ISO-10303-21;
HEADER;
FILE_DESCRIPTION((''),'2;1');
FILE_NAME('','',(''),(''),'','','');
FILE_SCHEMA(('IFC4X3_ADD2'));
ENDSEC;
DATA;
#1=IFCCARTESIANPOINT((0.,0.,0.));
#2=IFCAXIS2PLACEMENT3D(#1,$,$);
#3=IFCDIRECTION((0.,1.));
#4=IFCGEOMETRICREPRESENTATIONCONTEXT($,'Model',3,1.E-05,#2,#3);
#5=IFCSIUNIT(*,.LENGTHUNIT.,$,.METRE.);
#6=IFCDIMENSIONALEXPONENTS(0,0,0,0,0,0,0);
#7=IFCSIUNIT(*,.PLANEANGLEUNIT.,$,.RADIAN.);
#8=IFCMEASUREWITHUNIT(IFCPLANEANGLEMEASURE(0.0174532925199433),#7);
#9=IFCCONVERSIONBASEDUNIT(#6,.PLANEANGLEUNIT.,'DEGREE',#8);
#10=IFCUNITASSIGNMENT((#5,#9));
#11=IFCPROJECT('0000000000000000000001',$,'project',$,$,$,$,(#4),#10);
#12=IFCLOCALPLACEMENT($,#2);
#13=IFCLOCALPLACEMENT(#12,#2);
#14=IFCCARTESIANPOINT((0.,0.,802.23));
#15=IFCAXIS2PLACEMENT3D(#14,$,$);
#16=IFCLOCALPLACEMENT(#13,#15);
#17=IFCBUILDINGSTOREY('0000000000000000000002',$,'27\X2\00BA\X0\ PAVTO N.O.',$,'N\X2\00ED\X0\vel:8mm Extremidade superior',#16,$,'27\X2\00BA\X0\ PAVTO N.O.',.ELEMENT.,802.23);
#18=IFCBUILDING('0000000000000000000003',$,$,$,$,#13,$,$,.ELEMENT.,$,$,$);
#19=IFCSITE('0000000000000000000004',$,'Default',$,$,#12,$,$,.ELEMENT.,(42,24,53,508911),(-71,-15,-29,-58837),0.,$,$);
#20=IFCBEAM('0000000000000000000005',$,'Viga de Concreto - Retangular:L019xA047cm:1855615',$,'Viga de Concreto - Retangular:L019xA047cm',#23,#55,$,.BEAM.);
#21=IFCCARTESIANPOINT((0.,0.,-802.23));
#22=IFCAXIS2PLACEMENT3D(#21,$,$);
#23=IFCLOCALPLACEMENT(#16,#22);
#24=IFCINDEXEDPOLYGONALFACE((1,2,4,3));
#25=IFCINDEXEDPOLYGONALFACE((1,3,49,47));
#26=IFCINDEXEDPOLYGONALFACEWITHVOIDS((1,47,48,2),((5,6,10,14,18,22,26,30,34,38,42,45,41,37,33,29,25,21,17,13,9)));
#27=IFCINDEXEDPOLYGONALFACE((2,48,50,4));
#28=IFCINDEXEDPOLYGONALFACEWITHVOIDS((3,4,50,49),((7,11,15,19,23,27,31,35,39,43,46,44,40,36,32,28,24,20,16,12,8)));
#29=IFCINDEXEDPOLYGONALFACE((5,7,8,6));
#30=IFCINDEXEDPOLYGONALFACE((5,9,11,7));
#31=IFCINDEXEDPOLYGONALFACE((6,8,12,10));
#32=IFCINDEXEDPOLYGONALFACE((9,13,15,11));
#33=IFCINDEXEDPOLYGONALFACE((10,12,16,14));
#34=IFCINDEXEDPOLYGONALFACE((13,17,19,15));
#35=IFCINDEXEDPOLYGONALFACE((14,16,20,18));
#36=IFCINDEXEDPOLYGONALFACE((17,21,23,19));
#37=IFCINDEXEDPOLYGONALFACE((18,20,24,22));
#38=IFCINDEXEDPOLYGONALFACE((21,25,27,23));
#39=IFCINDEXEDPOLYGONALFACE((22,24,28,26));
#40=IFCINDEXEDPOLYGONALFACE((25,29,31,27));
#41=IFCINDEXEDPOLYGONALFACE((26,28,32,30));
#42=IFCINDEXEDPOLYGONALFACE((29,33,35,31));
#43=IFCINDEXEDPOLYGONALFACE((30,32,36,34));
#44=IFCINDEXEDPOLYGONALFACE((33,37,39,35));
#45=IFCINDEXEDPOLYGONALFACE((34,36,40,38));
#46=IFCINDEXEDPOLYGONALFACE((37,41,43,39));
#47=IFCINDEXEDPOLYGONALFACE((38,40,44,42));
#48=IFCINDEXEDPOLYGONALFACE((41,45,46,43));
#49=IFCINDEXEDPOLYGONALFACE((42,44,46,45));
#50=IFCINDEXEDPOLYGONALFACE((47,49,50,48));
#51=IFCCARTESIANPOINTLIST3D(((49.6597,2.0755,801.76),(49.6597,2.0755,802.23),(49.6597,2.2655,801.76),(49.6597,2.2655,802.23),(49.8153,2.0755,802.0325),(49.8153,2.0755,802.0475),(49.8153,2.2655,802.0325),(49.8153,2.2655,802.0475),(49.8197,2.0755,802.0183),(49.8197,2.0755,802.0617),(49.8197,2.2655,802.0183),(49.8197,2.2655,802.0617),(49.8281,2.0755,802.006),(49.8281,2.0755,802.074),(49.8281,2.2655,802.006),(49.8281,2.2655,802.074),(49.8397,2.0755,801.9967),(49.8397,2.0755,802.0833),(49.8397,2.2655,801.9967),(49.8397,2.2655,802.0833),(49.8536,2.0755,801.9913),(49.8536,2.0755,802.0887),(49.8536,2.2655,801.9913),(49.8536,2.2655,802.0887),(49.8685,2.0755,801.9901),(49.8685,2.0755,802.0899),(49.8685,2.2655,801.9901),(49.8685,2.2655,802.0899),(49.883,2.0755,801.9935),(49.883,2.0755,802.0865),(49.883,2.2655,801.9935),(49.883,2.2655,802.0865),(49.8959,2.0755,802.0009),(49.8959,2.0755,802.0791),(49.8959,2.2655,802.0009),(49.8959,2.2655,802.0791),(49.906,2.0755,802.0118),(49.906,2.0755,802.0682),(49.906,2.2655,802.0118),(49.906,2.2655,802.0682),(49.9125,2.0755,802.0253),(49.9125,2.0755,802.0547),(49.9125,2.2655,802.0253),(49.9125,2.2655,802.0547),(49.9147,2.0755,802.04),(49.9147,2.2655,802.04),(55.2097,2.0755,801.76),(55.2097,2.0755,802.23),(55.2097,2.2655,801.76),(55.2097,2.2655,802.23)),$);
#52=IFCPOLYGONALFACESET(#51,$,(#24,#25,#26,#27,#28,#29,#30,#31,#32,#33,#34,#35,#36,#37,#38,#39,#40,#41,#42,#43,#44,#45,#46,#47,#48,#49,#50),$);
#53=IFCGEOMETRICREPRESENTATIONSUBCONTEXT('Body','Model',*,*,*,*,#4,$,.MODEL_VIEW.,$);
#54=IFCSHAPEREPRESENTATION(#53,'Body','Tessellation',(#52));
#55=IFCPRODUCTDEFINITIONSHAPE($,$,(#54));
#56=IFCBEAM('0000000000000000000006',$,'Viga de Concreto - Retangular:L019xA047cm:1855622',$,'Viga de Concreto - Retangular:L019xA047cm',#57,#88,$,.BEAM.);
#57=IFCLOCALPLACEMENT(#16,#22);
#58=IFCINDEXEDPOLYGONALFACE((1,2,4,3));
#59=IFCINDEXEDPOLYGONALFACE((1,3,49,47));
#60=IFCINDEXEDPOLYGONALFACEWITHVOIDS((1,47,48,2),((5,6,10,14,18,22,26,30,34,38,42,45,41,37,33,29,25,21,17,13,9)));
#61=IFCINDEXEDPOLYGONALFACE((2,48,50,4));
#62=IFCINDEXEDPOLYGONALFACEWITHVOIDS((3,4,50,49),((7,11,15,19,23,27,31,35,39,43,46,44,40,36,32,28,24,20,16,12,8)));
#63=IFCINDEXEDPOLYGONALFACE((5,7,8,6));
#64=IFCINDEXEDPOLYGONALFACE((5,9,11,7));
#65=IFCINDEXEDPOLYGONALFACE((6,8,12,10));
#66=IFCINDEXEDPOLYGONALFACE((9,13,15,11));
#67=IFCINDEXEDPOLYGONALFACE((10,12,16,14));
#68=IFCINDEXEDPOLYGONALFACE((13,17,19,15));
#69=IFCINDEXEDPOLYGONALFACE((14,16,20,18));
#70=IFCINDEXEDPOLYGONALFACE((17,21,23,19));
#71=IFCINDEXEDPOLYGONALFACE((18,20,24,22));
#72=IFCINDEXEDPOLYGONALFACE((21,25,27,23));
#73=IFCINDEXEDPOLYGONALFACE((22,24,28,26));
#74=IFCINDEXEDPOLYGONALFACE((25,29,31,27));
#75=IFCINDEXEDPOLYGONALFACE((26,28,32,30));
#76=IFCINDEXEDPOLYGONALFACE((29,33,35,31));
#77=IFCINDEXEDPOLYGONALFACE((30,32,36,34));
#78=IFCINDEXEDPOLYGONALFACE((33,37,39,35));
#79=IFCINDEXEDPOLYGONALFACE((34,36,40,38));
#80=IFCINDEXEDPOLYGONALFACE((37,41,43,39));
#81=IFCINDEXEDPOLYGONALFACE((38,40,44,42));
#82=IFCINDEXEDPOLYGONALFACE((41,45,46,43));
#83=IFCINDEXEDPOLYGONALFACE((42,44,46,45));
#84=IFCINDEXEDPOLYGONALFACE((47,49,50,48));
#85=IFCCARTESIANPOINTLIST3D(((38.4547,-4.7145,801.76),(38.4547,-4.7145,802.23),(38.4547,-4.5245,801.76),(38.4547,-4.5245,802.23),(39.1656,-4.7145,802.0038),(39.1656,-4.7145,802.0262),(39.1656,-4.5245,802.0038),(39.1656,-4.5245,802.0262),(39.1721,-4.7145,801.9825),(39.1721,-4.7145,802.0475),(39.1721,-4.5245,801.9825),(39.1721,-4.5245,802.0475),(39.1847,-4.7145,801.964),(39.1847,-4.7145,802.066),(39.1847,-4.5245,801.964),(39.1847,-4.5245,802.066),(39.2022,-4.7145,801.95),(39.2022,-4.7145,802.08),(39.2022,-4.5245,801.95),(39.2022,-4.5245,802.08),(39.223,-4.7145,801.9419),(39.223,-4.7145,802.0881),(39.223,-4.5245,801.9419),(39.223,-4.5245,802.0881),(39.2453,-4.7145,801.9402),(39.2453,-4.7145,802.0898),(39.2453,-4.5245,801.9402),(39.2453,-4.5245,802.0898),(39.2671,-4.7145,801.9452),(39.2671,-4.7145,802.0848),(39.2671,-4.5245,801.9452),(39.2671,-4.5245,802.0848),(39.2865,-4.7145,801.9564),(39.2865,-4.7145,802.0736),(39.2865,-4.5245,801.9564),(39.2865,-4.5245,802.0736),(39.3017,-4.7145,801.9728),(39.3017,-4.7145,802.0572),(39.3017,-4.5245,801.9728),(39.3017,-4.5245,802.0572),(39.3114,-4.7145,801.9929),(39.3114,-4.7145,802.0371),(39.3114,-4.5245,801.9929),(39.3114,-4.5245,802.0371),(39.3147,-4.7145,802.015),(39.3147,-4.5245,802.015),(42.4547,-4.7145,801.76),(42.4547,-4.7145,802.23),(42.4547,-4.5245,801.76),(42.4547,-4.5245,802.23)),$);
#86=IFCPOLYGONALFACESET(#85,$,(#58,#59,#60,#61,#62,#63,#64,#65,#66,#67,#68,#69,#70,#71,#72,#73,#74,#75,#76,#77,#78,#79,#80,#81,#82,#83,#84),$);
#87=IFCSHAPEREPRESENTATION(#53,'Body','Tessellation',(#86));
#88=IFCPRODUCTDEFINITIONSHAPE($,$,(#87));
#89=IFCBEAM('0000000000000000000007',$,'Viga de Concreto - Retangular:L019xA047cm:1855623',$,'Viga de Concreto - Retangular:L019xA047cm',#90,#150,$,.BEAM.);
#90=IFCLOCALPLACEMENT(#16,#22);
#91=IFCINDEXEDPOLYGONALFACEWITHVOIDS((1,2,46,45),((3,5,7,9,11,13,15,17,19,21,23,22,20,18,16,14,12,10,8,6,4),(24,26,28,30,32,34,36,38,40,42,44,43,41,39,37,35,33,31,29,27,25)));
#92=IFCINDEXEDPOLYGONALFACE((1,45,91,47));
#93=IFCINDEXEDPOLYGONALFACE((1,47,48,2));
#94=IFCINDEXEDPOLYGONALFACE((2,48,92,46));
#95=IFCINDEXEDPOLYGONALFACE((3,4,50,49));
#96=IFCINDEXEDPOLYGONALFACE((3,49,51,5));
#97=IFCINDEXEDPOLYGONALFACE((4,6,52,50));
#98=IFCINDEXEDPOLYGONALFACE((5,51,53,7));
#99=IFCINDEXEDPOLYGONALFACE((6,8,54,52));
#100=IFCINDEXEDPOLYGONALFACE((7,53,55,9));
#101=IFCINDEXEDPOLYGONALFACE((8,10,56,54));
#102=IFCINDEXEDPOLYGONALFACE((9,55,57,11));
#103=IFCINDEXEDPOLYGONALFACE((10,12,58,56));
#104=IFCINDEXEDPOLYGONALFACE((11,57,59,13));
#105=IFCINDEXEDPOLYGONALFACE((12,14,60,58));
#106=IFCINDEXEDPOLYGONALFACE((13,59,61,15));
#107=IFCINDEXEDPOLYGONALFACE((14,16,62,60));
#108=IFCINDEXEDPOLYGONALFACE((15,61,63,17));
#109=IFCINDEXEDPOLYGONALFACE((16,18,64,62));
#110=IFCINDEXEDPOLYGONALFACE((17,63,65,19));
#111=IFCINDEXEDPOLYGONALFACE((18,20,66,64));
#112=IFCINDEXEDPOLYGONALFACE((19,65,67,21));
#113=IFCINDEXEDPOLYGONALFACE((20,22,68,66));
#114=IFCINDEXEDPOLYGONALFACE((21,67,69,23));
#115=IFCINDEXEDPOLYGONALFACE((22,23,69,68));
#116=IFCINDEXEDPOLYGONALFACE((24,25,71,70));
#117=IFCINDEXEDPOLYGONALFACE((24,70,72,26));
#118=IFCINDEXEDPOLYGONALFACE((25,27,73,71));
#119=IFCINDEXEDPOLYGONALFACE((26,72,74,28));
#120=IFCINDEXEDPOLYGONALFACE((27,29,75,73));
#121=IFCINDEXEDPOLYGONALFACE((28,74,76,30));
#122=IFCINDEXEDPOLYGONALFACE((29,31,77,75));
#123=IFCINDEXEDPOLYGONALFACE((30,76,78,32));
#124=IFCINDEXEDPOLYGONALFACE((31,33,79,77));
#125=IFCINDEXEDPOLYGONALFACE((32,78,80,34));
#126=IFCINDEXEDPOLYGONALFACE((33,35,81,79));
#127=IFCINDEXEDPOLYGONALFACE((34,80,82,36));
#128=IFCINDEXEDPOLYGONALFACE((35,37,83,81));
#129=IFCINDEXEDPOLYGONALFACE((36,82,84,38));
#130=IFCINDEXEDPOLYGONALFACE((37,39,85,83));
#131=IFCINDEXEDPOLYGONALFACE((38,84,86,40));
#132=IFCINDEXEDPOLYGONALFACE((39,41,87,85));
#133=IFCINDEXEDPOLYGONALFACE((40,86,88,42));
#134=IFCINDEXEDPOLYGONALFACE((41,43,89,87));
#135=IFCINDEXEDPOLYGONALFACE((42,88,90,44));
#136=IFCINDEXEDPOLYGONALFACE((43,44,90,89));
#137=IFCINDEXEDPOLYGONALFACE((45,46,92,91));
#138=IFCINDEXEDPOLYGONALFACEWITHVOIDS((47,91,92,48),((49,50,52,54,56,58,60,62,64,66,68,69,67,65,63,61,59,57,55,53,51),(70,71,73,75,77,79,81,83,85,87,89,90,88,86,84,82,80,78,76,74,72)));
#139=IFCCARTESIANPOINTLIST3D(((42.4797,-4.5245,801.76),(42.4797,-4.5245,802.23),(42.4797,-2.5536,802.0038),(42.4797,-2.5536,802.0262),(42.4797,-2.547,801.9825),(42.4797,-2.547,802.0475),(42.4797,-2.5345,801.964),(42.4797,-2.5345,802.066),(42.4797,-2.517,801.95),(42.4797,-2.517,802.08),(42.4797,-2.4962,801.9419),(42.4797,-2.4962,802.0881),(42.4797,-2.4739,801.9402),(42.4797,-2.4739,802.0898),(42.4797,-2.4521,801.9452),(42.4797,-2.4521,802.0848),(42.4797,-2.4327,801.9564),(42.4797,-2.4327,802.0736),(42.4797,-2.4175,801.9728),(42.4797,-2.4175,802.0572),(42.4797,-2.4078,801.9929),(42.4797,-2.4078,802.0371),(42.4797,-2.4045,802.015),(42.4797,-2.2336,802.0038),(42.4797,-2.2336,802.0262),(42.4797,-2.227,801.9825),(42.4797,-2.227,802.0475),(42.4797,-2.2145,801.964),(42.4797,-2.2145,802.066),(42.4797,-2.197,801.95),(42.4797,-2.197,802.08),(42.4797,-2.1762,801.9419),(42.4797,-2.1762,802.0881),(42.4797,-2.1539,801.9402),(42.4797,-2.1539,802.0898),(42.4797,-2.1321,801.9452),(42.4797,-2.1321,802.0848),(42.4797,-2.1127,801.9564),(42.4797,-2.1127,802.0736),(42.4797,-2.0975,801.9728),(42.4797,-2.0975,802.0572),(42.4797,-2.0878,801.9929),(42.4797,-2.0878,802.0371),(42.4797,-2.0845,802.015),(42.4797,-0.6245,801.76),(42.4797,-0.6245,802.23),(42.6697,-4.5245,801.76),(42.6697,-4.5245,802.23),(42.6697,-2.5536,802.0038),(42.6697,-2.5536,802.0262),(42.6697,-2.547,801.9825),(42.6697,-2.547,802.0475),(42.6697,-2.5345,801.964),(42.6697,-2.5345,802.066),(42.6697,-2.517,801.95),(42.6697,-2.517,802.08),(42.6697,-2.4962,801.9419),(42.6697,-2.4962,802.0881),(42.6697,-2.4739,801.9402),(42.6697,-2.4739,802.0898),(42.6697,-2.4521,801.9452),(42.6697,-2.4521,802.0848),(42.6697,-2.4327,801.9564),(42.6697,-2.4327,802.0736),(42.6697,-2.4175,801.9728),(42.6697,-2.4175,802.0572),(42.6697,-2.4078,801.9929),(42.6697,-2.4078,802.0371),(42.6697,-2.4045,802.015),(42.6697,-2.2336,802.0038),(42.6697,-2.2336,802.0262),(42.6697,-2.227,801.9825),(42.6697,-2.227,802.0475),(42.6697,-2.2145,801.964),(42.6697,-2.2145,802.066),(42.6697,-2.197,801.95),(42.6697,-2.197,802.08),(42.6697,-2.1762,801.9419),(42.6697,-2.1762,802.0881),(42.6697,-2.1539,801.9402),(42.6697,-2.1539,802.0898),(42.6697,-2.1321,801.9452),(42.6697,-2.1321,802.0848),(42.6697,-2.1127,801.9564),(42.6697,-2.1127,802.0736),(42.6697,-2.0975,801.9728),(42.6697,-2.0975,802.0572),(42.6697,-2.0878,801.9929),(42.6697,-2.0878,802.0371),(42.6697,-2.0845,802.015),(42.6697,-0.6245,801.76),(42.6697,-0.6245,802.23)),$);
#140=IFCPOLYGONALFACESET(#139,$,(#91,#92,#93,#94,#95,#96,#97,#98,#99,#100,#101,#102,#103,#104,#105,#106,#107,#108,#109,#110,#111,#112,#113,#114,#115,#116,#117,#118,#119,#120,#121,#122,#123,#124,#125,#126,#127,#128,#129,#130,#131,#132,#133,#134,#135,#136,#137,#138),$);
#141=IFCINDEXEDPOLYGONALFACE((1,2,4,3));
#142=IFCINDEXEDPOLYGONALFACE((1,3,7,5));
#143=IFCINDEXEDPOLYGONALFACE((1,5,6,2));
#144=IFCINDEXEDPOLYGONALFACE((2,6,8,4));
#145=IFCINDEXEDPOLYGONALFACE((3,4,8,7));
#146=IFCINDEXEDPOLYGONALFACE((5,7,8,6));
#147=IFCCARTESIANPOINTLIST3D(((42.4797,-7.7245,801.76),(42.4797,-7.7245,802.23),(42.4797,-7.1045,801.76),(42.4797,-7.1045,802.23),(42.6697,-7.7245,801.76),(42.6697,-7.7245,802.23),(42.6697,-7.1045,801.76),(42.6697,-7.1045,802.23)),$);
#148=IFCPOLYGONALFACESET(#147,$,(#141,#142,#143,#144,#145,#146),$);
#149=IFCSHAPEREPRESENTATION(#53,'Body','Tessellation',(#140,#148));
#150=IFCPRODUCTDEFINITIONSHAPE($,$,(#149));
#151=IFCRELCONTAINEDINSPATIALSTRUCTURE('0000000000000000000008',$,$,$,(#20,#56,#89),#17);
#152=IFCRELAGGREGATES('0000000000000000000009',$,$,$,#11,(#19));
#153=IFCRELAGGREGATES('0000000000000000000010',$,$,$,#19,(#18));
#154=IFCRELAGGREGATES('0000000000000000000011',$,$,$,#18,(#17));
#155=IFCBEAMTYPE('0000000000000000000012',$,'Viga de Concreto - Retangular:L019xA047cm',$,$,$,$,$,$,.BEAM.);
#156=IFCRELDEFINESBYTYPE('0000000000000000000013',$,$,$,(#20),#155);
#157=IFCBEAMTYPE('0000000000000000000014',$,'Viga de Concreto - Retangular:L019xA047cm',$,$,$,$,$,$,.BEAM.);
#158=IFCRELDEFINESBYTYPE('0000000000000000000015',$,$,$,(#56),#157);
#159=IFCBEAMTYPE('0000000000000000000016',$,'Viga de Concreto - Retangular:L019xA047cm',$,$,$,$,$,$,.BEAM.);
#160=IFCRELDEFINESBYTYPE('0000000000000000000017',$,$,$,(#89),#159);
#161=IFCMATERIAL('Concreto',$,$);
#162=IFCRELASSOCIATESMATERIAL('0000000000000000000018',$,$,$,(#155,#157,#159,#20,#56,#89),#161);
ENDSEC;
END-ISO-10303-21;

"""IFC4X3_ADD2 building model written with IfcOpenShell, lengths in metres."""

from ifc_helpers import new_model, entity, si_unit, converted_unit, direction, frame, frame_2d, origin, place, context, subcontext, project, spatial, rectangle, circle, extrude, boolean, source, transform, mapped, material, material_profile, profile_set, type_object, type_shapes, element, save


model = new_model("IFC4X3_ADD2")

# Units and contexts
model_context = context("Model", 3, precision=1e-05, world=origin(), true_north=direction((0.0, 1.0)))
body_context = subcontext(model_context, "Body", "Model", "MODEL_VIEW")
ifc_project = project(units=[si_unit("LENGTHUNIT", "METRE"), converted_unit("PLANEANGLEUNIT", "DEGREE", entity("IfcPlaneAngleMeasure", 0.0174532925199433), si_unit("PLANEANGLEUNIT", "RADIAN"), dimensions=[0, 0, 0, 0, 0, 0, 0])], contexts=[model_context])

# Site, building, storey
site_placement = place(None, origin())
site = spatial("IfcSite", under=ifc_project, at=site_placement, Name="Default", CompositionType="ELEMENT", RefLatitude=(42, 24, 53, 508911), RefLongitude=(-71, -15, -29, -58837), RefElevation=0.0)
building_placement = place(site_placement, origin())
building = spatial("IfcBuilding", under=site, at=building_placement, CompositionType="ELEMENT")
storey_placement = place(building_placement, frame((0.0, 0.0, 802.23)))
storey = spatial("IfcBuildingStorey", under=building, at=storey_placement, Name="27º PAVTO N.O.", ObjectType="Nível:8mm Extremidade superior", LongName="27º PAVTO N.O.", CompositionType="ELEMENT", Elevation=802.23)

# Beams
ifc_material = material(Name="Concreto")
ifc_material_profile_1 = material_profile(ifc_material, rectangle(XDim=0.47, YDim=0.19, at=frame_2d((0.0, 0.0), x_axis=(0.0, 1.0))), Name="L019xA047cm")
ifc_profile_set_1 = profile_set([ifc_material_profile_1], Name="L019xA047cm")
beam_type_1 = type_object("IfcBeamType", Name="Viga de Concreto - Retangular:L019xA047cm", PredefinedType="BEAM", material=ifc_profile_set_1)
shared_shape_1 = source(origin(), body_context, "Body", "CSG", [
    boolean("DIFFERENCE", extrude(rectangle(XDim=0.47, YDim=0.19, at=frame_2d((0.0, 0.0), x_axis=(0.0, 1.0))), frame((49.6597, 2.1705, 801.995), z_axis=(1.0, 0.0, 0.0), x_axis=(0.0, 1.0, 0.0)), (0.0, 0.0, 1.0), 5.55), extrude(circle(Radius=0.05, at=frame_2d((0.0, 0.0), x_axis=(1.0, 0.0))), frame((49.8647, 2.0755, 802.04), z_axis=(0.0, 1.0, 0.0), x_axis=(1.0, 0.0, 0.0)), (0.0, 0.0, 1.0), 0.19)),
])
type_shapes(beam_type_1, [shared_shape_1])
beam_1_placement = place(storey_placement, frame((0.0, 0.0, -802.23)))
element("IfcBeam", 1, at=beam_1_placement, inside=storey, type_object=beam_type_1, material=ifc_material, Name="Viga de Concreto - Retangular:L019xA047cm:1855615", ObjectType="Viga de Concreto - Retangular:L019xA047cm", PredefinedType="BEAM", context=body_context, shape_type="MappedRepresentation", body=[
    mapped(shared_shape_1, transform((0.0, 0.0, 0.0), scale=1.0)),
])
beam_type_2 = type_object("IfcBeamType", Name="Viga de Concreto - Retangular:L019xA047cm", PredefinedType="BEAM", material=ifc_profile_set_1)
shared_shape_2 = source(origin(), body_context, "Body", "CSG", [
    boolean("DIFFERENCE", extrude(rectangle(XDim=0.47, YDim=0.19, at=frame_2d((0.0, 0.0), x_axis=(0.0, 1.0))), frame((38.4547, -4.6195, 801.995), z_axis=(1.0, 0.0, 0.0), x_axis=(0.0, 1.0, 0.0)), (0.0, 0.0, 1.0), 4.0), extrude(circle(Radius=0.075, at=frame_2d((0.0, 0.0), x_axis=(1.0, 0.0))), frame((39.2397, -4.7145, 802.015), z_axis=(0.0, 1.0, 0.0), x_axis=(1.0, 0.0, 0.0)), (0.0, 0.0, 1.0), 0.19)),
])
type_shapes(beam_type_2, [shared_shape_2])
beam_2_placement = place(storey_placement, frame((0.0, 0.0, -802.23)))
element("IfcBeam", 2, at=beam_2_placement, inside=storey, type_object=beam_type_2, material=ifc_material, Name="Viga de Concreto - Retangular:L019xA047cm:1855622", ObjectType="Viga de Concreto - Retangular:L019xA047cm", PredefinedType="BEAM", context=body_context, shape_type="MappedRepresentation", body=[
    mapped(shared_shape_2, transform((0.0, 0.0, 0.0), scale=1.0)),
])
beam_type_3 = type_object("IfcBeamType", Name="Viga de Concreto - Retangular:L019xA047cm", PredefinedType="BEAM", material=ifc_profile_set_1)
shared_shape_3 = source(origin(), body_context, "Body", "SweptSolid", [
    boolean("DIFFERENCE", boolean("DIFFERENCE", extrude(rectangle(XDim=0.47, YDim=0.19, at=frame_2d((0.0, 0.0), x_axis=(0.0, 1.0))), frame((42.5747, -4.5245, 801.995), z_axis=(0.0, 1.0, 0.0), x_axis=(-1.0, 0.0, 0.0)), (0.0, 0.0, 1.0), 3.9), extrude(circle(Radius=0.075, at=frame_2d((0.0, 0.0), x_axis=(1.0, 0.0))), frame((42.6697, -2.4795, 802.015), z_axis=(-1.0, 0.0, 0.0), x_axis=(0.0, 1.0, 0.0)), (0.0, 0.0, 1.0), 0.19)), extrude(circle(Radius=0.075, at=frame_2d((0.0, 0.0), x_axis=(1.0, 0.0))), frame((42.6697, -2.1595, 802.015), z_axis=(-1.0, 0.0, 0.0), x_axis=(0.0, 1.0, 0.0)), (0.0, 0.0, 1.0), 0.19)),
    extrude(rectangle(XDim=0.47, YDim=0.19, at=frame_2d((0.0, 0.0), x_axis=(0.0, 1.0))), frame((42.5747, -7.7245, 801.995), z_axis=(0.0, 1.0, 0.0), x_axis=(-1.0, 0.0, 0.0)), (0.0, 0.0, 1.0), 0.62),
])
type_shapes(beam_type_3, [shared_shape_3])
beam_3_placement = place(storey_placement, frame((0.0, 0.0, -802.23)))
element("IfcBeam", 3, at=beam_3_placement, inside=storey, type_object=beam_type_3, material=ifc_material, Name="Viga de Concreto - Retangular:L019xA047cm:1855623", ObjectType="Viga de Concreto - Retangular:L019xA047cm", PredefinedType="BEAM", context=body_context, shape_type="MappedRepresentation", body=[
    mapped(shared_shape_3, transform((0.0, 0.0, 0.0), scale=1.0)),
])

save(model, "model.ifc")
